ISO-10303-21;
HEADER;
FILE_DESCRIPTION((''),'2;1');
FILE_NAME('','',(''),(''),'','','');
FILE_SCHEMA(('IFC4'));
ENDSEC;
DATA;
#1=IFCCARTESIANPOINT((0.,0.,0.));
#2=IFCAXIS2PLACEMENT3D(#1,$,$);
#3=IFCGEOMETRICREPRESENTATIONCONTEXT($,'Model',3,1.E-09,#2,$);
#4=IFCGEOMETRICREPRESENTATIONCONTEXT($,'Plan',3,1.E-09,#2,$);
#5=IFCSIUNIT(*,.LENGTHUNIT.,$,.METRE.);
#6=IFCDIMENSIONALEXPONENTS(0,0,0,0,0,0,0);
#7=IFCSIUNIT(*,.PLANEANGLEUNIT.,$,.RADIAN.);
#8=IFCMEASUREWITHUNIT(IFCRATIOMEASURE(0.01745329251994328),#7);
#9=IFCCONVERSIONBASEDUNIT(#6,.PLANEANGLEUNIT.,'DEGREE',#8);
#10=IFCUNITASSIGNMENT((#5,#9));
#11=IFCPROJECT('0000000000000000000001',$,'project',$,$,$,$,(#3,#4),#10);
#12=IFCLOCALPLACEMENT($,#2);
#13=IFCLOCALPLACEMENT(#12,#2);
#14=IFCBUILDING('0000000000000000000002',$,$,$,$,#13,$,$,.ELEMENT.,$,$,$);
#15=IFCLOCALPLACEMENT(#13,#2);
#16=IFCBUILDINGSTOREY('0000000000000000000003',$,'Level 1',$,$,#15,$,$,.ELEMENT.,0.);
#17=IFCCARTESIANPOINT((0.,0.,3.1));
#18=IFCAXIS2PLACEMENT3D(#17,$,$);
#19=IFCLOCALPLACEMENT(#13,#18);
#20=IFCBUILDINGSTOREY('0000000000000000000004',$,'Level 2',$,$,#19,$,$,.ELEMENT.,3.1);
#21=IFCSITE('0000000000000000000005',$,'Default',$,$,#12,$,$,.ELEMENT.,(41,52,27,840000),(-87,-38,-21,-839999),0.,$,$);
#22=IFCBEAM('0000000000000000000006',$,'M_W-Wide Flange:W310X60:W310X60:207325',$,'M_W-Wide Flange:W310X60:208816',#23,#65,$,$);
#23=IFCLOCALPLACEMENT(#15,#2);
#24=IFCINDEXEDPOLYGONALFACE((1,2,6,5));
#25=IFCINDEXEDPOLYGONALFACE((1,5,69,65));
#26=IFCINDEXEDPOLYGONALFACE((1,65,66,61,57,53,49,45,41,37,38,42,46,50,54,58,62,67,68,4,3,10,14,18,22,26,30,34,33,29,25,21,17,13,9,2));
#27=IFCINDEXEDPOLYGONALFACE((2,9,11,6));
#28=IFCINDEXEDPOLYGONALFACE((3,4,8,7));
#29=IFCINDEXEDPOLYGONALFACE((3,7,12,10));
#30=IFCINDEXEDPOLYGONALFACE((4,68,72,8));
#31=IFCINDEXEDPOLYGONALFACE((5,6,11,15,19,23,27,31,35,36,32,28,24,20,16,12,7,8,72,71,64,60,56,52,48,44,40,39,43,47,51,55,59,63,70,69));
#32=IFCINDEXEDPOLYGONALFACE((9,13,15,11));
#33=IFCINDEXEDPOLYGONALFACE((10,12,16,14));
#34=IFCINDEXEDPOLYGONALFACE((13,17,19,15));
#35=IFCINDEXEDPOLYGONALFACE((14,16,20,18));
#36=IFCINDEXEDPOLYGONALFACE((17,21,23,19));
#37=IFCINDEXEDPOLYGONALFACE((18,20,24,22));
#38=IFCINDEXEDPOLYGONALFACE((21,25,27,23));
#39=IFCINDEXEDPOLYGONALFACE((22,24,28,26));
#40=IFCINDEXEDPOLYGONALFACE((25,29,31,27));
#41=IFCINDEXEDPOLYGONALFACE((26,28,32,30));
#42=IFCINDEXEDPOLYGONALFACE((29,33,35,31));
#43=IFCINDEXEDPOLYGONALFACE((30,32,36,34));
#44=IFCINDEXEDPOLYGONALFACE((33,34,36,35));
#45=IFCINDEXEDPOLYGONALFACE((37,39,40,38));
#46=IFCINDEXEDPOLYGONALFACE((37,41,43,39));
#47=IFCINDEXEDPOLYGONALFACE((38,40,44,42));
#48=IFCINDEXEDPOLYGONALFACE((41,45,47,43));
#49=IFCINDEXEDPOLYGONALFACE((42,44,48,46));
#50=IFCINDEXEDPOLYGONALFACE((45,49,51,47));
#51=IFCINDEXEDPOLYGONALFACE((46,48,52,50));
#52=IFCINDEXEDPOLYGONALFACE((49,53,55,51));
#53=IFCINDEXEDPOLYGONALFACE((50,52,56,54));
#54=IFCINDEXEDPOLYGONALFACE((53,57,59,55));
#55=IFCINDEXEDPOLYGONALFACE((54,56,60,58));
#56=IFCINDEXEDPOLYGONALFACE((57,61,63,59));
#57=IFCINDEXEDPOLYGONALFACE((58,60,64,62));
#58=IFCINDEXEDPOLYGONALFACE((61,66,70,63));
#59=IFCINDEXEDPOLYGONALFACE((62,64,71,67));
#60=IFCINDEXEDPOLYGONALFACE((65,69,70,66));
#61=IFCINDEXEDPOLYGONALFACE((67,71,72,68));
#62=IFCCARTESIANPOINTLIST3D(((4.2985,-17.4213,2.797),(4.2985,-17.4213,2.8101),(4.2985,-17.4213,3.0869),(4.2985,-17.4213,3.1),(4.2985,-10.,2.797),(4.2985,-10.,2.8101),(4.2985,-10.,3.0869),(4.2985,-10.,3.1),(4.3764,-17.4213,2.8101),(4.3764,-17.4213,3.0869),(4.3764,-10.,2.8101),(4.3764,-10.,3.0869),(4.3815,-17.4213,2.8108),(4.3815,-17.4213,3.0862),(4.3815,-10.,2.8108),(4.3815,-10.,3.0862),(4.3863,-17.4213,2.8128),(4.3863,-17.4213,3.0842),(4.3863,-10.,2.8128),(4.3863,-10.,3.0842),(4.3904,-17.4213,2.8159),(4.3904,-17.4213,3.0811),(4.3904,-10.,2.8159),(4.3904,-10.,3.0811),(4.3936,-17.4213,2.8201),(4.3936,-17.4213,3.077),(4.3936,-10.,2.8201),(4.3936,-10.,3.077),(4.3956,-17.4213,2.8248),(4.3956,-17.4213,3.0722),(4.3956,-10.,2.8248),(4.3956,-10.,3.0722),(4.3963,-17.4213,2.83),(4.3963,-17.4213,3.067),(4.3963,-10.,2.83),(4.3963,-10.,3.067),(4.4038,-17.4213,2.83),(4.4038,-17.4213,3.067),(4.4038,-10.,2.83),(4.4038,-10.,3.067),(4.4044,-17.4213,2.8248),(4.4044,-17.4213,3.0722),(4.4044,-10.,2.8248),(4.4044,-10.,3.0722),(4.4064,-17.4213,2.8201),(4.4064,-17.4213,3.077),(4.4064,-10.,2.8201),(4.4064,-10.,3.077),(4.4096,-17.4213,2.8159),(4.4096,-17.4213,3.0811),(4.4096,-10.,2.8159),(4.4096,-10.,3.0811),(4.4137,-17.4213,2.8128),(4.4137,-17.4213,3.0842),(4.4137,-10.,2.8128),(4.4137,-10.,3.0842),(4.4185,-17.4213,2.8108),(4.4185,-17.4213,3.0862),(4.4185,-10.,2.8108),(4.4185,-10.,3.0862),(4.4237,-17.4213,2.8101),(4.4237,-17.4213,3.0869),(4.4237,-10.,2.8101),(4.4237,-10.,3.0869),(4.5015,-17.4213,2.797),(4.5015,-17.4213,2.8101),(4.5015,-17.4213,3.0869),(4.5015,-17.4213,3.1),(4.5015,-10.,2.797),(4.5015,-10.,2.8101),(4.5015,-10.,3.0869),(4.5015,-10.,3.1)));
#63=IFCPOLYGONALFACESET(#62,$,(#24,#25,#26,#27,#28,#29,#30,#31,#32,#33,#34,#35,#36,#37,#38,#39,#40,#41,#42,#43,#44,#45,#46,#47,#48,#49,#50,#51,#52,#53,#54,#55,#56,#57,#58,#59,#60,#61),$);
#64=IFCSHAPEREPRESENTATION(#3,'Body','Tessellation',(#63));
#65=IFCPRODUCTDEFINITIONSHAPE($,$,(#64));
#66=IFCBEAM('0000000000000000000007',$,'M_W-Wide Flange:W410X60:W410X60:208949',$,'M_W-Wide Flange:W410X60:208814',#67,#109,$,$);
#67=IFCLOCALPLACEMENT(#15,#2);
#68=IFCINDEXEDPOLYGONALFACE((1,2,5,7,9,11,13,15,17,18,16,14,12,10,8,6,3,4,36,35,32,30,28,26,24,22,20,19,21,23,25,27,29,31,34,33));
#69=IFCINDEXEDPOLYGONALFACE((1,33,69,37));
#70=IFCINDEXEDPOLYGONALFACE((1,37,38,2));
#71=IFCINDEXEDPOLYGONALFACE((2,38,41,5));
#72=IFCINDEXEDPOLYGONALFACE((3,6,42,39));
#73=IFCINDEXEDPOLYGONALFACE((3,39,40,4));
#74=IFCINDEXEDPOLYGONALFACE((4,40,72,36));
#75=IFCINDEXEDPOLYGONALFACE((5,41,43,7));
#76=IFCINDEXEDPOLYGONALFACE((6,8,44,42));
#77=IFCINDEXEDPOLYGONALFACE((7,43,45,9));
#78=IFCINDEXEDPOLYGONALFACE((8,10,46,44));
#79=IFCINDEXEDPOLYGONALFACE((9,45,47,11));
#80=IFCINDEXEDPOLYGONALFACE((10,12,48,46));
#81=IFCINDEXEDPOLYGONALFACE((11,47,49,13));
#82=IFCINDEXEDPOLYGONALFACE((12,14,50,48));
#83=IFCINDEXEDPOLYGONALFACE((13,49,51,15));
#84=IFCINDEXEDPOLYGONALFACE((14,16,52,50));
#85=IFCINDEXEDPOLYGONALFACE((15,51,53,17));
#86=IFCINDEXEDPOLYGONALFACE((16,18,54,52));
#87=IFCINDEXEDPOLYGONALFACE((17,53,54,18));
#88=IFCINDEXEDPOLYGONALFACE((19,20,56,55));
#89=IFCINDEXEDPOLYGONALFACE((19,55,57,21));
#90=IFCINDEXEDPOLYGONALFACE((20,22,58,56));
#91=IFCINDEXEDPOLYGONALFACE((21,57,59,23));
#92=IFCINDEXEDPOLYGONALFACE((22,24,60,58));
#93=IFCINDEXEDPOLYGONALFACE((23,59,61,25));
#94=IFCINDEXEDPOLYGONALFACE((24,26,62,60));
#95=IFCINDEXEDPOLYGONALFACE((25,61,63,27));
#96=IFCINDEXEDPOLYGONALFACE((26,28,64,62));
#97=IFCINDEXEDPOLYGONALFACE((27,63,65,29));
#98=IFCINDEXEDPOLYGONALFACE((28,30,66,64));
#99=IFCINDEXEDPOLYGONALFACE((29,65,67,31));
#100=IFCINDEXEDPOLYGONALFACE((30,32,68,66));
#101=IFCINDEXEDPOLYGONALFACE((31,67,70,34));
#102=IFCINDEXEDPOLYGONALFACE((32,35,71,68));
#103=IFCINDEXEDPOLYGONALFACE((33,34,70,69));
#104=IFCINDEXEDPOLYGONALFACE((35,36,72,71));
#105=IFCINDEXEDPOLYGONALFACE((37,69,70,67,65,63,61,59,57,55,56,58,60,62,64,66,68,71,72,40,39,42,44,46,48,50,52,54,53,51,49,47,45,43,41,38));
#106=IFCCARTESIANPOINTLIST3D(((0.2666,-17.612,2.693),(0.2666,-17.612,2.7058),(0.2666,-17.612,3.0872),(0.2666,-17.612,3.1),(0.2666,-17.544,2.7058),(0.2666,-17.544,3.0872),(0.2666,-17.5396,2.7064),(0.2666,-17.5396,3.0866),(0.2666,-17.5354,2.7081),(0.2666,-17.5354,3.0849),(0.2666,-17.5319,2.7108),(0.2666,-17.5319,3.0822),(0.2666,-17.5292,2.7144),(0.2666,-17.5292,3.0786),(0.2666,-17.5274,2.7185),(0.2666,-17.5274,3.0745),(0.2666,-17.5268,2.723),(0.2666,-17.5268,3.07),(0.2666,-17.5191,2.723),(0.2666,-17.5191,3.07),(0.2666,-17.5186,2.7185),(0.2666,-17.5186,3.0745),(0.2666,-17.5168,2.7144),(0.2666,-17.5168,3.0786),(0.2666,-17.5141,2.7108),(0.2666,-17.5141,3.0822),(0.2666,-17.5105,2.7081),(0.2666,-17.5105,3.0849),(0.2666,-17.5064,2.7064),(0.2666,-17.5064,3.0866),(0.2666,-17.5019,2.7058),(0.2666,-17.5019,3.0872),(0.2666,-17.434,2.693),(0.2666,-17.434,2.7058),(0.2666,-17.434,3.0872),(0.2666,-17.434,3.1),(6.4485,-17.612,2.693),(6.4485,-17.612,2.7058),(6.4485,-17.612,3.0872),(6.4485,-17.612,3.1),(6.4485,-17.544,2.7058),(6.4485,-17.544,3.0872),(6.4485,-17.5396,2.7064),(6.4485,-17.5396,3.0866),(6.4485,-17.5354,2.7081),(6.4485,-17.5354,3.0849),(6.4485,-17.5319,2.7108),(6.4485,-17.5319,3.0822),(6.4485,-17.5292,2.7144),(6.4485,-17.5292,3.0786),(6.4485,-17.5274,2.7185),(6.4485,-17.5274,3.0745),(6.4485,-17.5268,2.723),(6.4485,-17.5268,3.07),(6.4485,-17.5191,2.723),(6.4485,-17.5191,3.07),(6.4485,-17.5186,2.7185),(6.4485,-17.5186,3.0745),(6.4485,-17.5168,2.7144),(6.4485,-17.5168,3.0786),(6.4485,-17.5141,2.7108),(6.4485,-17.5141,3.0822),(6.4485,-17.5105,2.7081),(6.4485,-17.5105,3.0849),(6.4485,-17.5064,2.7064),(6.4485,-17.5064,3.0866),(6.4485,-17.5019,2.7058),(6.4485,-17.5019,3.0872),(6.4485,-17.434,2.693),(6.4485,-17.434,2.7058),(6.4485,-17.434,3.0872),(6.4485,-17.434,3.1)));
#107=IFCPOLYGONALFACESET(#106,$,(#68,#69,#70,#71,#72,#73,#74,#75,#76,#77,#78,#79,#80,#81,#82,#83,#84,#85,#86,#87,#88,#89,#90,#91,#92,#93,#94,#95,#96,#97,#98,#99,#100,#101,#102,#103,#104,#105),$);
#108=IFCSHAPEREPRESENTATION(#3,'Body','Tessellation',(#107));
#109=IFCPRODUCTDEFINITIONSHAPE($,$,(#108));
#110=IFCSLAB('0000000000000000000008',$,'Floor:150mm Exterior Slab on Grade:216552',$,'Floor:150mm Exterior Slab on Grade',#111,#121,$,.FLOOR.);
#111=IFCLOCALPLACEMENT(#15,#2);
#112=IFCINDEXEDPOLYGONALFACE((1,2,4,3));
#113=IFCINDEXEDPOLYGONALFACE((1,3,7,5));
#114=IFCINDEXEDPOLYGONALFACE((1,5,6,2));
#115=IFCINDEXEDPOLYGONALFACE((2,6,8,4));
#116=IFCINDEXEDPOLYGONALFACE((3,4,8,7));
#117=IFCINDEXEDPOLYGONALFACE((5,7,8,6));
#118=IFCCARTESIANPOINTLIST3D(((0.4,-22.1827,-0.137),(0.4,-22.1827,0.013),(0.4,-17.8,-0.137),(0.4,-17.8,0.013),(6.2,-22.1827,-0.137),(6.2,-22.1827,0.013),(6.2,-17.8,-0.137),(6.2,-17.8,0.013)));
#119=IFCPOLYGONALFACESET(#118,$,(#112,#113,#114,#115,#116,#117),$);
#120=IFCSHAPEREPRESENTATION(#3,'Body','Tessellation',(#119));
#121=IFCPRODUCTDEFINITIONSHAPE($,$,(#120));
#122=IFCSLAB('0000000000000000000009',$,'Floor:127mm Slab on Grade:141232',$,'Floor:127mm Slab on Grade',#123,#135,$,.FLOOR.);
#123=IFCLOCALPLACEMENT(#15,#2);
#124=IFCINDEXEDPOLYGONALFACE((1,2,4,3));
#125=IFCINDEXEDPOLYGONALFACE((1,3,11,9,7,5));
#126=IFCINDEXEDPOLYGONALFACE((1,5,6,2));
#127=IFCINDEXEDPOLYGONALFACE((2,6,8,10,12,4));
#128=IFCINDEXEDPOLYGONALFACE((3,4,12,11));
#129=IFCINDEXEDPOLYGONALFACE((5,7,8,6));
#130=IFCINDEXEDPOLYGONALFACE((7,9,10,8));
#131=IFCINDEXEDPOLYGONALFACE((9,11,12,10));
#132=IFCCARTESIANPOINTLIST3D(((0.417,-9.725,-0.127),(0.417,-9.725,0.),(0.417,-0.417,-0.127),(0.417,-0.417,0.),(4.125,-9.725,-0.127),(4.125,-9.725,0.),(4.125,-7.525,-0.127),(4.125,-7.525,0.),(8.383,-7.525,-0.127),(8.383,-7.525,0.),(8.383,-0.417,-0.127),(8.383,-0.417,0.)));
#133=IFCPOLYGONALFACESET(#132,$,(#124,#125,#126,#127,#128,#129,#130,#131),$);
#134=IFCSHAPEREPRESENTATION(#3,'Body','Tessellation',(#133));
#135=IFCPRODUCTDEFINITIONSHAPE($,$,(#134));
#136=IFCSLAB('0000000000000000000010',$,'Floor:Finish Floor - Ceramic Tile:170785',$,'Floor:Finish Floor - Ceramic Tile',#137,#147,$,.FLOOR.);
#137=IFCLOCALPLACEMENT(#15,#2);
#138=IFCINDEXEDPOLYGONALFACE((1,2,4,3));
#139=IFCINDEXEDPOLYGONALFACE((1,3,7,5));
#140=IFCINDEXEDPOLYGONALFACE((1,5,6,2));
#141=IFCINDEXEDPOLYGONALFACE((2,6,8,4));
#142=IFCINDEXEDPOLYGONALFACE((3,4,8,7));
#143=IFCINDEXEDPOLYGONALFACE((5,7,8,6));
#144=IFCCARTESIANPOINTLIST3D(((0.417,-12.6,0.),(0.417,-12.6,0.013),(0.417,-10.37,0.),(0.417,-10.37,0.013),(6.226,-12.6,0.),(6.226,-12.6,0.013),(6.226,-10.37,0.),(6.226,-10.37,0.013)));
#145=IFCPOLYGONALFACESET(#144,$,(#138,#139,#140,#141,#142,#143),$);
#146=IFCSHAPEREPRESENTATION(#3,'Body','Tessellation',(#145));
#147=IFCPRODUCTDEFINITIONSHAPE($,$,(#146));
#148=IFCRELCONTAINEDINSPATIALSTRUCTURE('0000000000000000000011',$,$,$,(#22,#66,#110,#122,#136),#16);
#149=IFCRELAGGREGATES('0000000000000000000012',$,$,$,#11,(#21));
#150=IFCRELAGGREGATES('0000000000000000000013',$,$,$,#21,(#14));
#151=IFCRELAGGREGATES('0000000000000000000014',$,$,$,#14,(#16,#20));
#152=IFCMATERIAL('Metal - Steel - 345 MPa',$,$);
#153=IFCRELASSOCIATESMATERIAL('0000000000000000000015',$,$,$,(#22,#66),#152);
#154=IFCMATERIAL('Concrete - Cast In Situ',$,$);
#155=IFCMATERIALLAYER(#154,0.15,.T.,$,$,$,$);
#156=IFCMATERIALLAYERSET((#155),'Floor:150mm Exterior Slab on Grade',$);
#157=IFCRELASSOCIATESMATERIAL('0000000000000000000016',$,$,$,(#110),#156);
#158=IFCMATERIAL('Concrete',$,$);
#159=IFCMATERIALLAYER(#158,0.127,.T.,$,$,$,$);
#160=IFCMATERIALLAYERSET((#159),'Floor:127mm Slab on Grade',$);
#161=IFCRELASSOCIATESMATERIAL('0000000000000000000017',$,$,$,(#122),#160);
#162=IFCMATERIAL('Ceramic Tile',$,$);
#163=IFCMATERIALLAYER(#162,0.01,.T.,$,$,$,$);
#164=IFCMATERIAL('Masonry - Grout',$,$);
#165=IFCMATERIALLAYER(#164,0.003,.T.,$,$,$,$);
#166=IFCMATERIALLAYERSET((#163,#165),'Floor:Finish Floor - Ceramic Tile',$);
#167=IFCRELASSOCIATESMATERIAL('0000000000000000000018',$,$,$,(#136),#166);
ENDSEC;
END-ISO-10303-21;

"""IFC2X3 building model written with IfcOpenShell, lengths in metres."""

from ifc_helpers import new_model, entity, si_unit, converted_unit, frame, frame_2d, origin, origin_2d_with_axis, place, context, project, spatial, polyline, circle_curve, parameter, trimmed, segment, composite_curve, rectangle, outline, extrude, material, layer, layer_set, layer_usage, element, save


model = new_model("IFC2X3")

# Units and contexts
model_context = context("Model", 3, precision=1e-09, world=origin())
plan_context = context("Plan", 3, precision=1e-09, world=origin())
ifc_project = project(units=[si_unit("LENGTHUNIT", "METRE"), converted_unit("PLANEANGLEUNIT", "DEGREE", entity("IfcRatioMeasure", 0.01745329251994328), si_unit("PLANEANGLEUNIT", "RADIAN"), dimensions=[0, 0, 0, 0, 0, 0, 0])], contexts=[model_context, plan_context])

# Site, building, storey
site_placement = place(None, origin())
site = spatial("IfcSite", under=ifc_project, at=site_placement, Name="Default", CompositionType="ELEMENT", RefLatitude=(41, 52, 27, 840000), RefLongitude=(-87, -38, -21, -839999), RefElevation=0.0)
building_placement = place(site_placement, origin())
building = spatial("IfcBuilding", under=site, at=building_placement, CompositionType="ELEMENT")
storey_1_placement = place(building_placement, origin())
storey_1 = spatial("IfcBuildingStorey", under=building, at=storey_1_placement, Name="Level 1", CompositionType="ELEMENT", Elevation=0.0)

# Beams
ifc_material_1 = material(Name="Metal - Steel - 345 MPa")
beam_1_placement = place(storey_1_placement, frame((4.4, -10.0, 3.1), z_axis=(0.0, 0.0, 1.0), x_axis=(-1.0, 0.0, 0.0)))
element("IfcBeam", 1, at=beam_1_placement, inside=storey_1, material=ifc_material_1, Name="M_W-Wide Flange:W310X60:W310X60:207325", ObjectType="M_W-Wide Flange:W310X60:208816", context=model_context, shape_type="SweptSolid", body=[
    extrude(outline(composite_curve([segment(polyline([(0.1384, -0.1015), (0.1515, -0.1015)]), True, "CONTINUOUS"), segment(polyline([(0.1515, -0.1015), (0.1515, 0.1015)]), True, "CONTINUOUS"), segment(polyline([(0.1515, 0.1015), (0.1384, 0.1015)]), True, "CONTINUOUS"), segment(polyline([(0.1384, 0.1015), (0.1384, 0.0236)]), True, "CONTINUOUS"), segment(trimmed(circle_curve(frame_2d((0.1185, 0.0236), x_axis=(0.0, 1.0)), 0.0199), [parameter(180.0)], [parameter(270.0)], True, "PARAMETER"), False, "CONTINUOUS"), segment(polyline([(0.1185, 0.0037), (-0.1185, 0.0037)]), True, "CONTINUOUS"), segment(trimmed(circle_curve(frame_2d((-0.1185, 0.0236), x_axis=(0.0, 1.0)), 0.0199), [parameter(90.0)], [parameter(180.0)], True, "PARAMETER"), False, "CONTINUOUS"), segment(polyline([(-0.1384, 0.0236), (-0.1384, 0.1015)]), True, "CONTINUOUS"), segment(polyline([(-0.1384, 0.1015), (-0.1515, 0.1015)]), True, "CONTINUOUS"), segment(polyline([(-0.1515, 0.1015), (-0.1515, -0.1015)]), True, "CONTINUOUS"), segment(polyline([(-0.1515, -0.1015), (-0.1384, -0.1015)]), True, "CONTINUOUS"), segment(polyline([(-0.1384, -0.1015), (-0.1384, -0.0237)]), True, "CONTINUOUS"), segment(trimmed(circle_curve(frame_2d((-0.1185, -0.0237), x_axis=(0.0, 1.0)), 0.0199), [parameter(360.0)], [parameter(90.0)], True, "PARAMETER"), False, "CONTINUOUS"), segment(polyline([(-0.1185, -0.0038), (0.1185, -0.0038)]), True, "CONTINUOUS"), segment(trimmed(circle_curve(frame_2d((0.1185, -0.0237), x_axis=(0.0, 1.0)), 0.0199), [parameter(270.0)], [parameter(0.0)], True, "PARAMETER"), False, "CONTINUOUS"), segment(polyline([(0.1384, -0.0237), (0.1384, -0.1015)]), True, "CONTINUOUS")], self_intersect=False)), frame((0.0, 7.4213, -0.1515), z_axis=(0.0, -1.0, 0.0), x_axis=(0.0, 0.0, -1.0)), (0.0, 0.0, 1.0), 7.4213),
])
beam_2_placement = place(storey_1_placement, frame((0.2085, -17.523, 3.1), z_axis=(0.0, 0.0, 1.0), x_axis=(0.0, -1.0, 0.0)))
element("IfcBeam", 2, at=beam_2_placement, inside=storey_1, material=ifc_material_1, Name="M_W-Wide Flange:W410X60:W410X60:208949", ObjectType="M_W-Wide Flange:W410X60:208814", context=model_context, shape_type="SweptSolid", body=[
    extrude(outline(composite_curve([segment(polyline([(-0.089, -0.1907), (-0.089, -0.2035)]), True, "CONTINUOUS"), segment(polyline([(-0.089, -0.2035), (0.089, -0.2035)]), True, "CONTINUOUS"), segment(polyline([(0.089, -0.2035), (0.089, -0.1907)]), True, "CONTINUOUS"), segment(polyline([(0.089, -0.1907), (0.021, -0.1907)]), True, "CONTINUOUS"), segment(trimmed(circle_curve(frame_2d((0.021, -0.1735), x_axis=(0.0, -1.0)), 0.0172), [parameter(270.0)], [parameter(360.0)], True, "PARAMETER"), False, "CONTINUOUS"), segment(polyline([(0.0038, -0.1735), (0.0038, 0.1735)]), True, "CONTINUOUS"), segment(trimmed(circle_curve(frame_2d((0.021, 0.1735), x_axis=(-1.0, 0.0)), 0.0172), [parameter(270.0)], [parameter(360.0)], True, "PARAMETER"), False, "CONTINUOUS"), segment(polyline([(0.021, 0.1907), (0.089, 0.1907)]), True, "CONTINUOUS"), segment(polyline([(0.089, 0.1907), (0.089, 0.2035)]), True, "CONTINUOUS"), segment(polyline([(0.089, 0.2035), (-0.089, 0.2035)]), True, "CONTINUOUS"), segment(polyline([(-0.089, 0.2035), (-0.089, 0.1907)]), True, "CONTINUOUS"), segment(polyline([(-0.089, 0.1907), (-0.0211, 0.1907)]), True, "CONTINUOUS"), segment(trimmed(circle_curve(frame_2d((-0.0211, 0.1735), x_axis=(0.0, 1.0)), 0.0172), [parameter(270.0)], [parameter(0.0)], True, "PARAMETER"), False, "CONTINUOUS"), segment(polyline([(-0.0039, 0.1735), (-0.0039, -0.1735)]), True, "CONTINUOUS"), segment(trimmed(circle_curve(frame_2d((-0.0211, -0.1735), x_axis=(1.0, 0.0)), 0.0172), [parameter(270.0)], [parameter(0.0)], True, "PARAMETER"), False, "CONTINUOUS"), segment(polyline([(-0.0211, -0.1907), (-0.089, -0.1907)]), True, "CONTINUOUS")], self_intersect=False)), frame((0.0, 0.0581, -0.2035), z_axis=(0.0, -1.0, 0.0), x_axis=(1.0, 0.0, 0.0)), (0.0, 0.0, -1.0), 6.1819),
])

# Slabs
ifc_material_2 = material(Name="Concrete - Cast In Situ")
ifc_layer_1 = layer(ifc_material_2, 0.15, ventilated=True)
ifc_layer_set_1 = layer_set([ifc_layer_1], Name="Floor:150mm Exterior Slab on Grade")
ifc_layer_usage_1 = layer_usage(ifc_layer_set_1, "AXIS3", "POSITIVE", 0.0)
slab_1_placement = place(storey_1_placement, frame((0.4, -22.1827, -0.137)))
element("IfcSlab", 3, at=slab_1_placement, inside=storey_1, material=ifc_layer_usage_1, Name="Floor:150mm Exterior Slab on Grade:216552", ObjectType="Floor:150mm Exterior Slab on Grade", PredefinedType="FLOOR", context=model_context, shape_type="SweptSolid", body=[
    extrude(rectangle(XDim=5.8, YDim=4.3827, at=origin_2d_with_axis()), frame((2.9, 2.1914, 0.15), z_axis=(0.0, 0.0, -1.0), x_axis=(-1.0, 0.0, 0.0)), (0.0, 0.0, 1.0), 0.15),
])
ifc_material_3 = material(Name="Concrete")
ifc_layer_2 = layer(ifc_material_3, 0.127, ventilated=True)
ifc_layer_set_2 = layer_set([ifc_layer_2], Name="Floor:127mm Slab on Grade")
ifc_layer_usage_2 = layer_usage(ifc_layer_set_2, "AXIS3", "POSITIVE", 0.0)
slab_2_placement = place(storey_1_placement, frame((0.417, -9.725, -0.127)))
element("IfcSlab", 4, at=slab_2_placement, inside=storey_1, material=ifc_layer_usage_2, Name="Floor:127mm Slab on Grade:141232", ObjectType="Floor:127mm Slab on Grade", PredefinedType="FLOOR", context=model_context, shape_type="SweptSolid", body=[
    extrude(outline(polyline([(-3.983, 4.654), (-3.983, -2.454), (0.275, -2.454), (0.275, -4.654), (3.983, -4.654), (3.983, 4.654), (-3.983, 4.654)])), frame((3.983, 4.654, 0.127), z_axis=(0.0, 0.0, -1.0), x_axis=(-1.0, 0.0, 0.0)), (0.0, 0.0, 1.0), 0.127),
])
ifc_material_4 = material(Name="Ceramic Tile")
ifc_layer_3 = layer(ifc_material_4, 0.01, ventilated=True)
ifc_material_5 = material(Name="Masonry - Grout")
ifc_layer_4 = layer(ifc_material_5, 0.003, ventilated=True)
ifc_layer_set_3 = layer_set([ifc_layer_3, ifc_layer_4], Name="Floor:Finish Floor - Ceramic Tile")
ifc_layer_usage_3 = layer_usage(ifc_layer_set_3, "AXIS3", "POSITIVE", 0.0)
slab_3_placement = place(storey_1_placement, frame((0.417, -12.6, 0.0)))
element("IfcSlab", 5, at=slab_3_placement, inside=storey_1, material=ifc_layer_usage_3, Name="Floor:Finish Floor - Ceramic Tile:170785", ObjectType="Floor:Finish Floor - Ceramic Tile", PredefinedType="FLOOR", context=model_context, shape_type="SweptSolid", body=[
    extrude(rectangle(XDim=5.809, YDim=2.23, at=frame_2d((0.0, 0.0), x_axis=(-1.0, 0.0))), frame((2.9045, 1.115, 0.013), z_axis=(0.0, 0.0, -1.0), x_axis=(-1.0, 0.0, 0.0)), (0.0, 0.0, 1.0), 0.013),
])

# Shared definitions
storey_2_placement = place(building_placement, frame((0.0, 0.0, 3.1)))
storey_2 = spatial("IfcBuildingStorey", under=building, at=storey_2_placement, Name="Level 2", CompositionType="ELEMENT", Elevation=3.1)

save(model, "model.ifc")
